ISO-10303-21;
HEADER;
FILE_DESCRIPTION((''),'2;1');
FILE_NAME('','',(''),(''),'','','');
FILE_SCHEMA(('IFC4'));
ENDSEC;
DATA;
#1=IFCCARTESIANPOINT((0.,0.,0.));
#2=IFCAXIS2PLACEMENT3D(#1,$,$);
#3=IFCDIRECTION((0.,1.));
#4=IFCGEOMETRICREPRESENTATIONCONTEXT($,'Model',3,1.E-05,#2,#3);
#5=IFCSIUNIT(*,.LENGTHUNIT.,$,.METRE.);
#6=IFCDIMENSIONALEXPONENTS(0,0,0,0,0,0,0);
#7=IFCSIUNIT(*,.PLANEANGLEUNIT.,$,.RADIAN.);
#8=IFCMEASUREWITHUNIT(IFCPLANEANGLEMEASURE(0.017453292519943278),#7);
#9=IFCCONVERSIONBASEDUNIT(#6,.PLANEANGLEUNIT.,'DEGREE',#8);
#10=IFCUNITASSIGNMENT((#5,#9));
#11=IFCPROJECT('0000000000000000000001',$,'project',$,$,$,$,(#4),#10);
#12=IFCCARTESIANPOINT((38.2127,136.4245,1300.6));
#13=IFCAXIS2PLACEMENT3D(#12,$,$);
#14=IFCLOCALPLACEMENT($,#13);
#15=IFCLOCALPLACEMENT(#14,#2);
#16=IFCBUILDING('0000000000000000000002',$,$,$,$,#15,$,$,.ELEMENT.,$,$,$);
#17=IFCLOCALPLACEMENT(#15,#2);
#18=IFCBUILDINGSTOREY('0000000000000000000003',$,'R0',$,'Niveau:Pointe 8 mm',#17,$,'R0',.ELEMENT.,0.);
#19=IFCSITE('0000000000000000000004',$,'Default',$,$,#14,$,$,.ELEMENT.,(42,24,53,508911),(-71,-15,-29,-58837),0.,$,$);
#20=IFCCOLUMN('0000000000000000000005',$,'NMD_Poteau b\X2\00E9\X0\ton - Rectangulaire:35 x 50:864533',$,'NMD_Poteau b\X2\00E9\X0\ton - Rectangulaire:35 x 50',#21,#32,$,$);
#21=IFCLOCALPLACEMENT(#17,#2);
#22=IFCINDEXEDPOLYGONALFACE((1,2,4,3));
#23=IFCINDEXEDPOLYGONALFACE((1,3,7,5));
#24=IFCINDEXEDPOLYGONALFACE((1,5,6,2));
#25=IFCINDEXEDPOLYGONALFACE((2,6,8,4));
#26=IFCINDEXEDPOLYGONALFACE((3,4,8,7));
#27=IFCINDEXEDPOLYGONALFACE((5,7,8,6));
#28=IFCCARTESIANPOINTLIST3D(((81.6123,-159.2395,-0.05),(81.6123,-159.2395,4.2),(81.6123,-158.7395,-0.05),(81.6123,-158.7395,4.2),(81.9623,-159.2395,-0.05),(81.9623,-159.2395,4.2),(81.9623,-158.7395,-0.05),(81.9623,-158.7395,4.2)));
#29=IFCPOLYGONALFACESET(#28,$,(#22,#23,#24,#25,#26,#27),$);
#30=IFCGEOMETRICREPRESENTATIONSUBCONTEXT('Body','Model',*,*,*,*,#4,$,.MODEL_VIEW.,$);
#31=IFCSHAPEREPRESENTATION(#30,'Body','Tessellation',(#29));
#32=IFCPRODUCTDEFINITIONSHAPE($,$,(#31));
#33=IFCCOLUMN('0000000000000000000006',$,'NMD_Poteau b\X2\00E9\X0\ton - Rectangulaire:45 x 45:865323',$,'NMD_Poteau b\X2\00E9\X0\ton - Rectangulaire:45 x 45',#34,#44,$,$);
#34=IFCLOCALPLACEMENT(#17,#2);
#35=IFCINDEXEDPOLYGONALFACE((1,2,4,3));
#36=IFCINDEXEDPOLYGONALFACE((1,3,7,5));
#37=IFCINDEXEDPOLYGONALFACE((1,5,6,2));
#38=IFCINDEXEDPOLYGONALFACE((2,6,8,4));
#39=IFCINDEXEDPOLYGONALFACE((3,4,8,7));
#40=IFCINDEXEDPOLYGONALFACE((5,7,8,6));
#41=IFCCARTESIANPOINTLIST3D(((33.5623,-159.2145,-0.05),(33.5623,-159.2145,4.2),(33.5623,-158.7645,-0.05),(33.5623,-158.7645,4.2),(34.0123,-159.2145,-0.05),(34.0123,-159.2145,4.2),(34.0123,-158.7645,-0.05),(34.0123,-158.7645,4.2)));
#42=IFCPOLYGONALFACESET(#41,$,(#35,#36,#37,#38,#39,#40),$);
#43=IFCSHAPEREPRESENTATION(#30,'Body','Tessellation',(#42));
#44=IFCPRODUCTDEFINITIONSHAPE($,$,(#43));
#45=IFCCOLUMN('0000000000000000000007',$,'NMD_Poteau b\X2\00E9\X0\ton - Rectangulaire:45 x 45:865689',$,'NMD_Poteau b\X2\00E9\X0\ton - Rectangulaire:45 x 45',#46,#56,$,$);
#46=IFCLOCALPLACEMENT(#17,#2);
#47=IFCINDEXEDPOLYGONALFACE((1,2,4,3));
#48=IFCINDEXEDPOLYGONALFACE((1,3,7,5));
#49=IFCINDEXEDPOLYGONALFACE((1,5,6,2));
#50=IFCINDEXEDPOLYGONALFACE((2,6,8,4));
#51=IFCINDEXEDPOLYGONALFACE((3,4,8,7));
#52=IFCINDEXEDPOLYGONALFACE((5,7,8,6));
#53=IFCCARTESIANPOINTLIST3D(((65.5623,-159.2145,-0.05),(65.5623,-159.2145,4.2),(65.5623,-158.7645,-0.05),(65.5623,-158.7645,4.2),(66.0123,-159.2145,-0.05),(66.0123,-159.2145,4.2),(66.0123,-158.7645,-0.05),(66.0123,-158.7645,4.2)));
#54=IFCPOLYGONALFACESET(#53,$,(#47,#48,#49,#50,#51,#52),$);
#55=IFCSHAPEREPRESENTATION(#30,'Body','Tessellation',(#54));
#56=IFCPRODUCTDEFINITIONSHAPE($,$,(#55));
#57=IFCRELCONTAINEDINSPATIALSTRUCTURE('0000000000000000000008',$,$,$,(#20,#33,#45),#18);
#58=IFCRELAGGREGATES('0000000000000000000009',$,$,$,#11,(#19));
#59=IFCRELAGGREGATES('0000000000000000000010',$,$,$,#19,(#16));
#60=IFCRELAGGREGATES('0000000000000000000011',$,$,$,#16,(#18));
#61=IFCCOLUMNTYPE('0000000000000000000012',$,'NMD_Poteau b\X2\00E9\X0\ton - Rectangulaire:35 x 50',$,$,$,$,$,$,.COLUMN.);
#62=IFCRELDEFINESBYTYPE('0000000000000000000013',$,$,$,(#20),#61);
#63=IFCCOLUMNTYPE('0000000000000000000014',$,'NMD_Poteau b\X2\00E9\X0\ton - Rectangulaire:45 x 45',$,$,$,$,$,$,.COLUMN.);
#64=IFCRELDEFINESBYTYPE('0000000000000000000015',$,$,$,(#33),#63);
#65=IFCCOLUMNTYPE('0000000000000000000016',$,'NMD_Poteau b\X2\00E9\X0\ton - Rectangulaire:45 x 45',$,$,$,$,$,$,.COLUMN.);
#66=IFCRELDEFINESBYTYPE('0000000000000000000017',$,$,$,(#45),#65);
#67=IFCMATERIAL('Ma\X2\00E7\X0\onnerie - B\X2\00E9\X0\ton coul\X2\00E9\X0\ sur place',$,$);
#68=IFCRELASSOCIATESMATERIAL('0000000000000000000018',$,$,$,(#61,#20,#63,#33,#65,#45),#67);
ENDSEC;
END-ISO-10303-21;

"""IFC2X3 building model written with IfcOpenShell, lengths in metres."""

from ifc_helpers import new_model, entity, si_unit, converted_unit, direction, frame, frame_2d, origin, origin_2d_with_axis, place, context, subcontext, project, spatial, rectangle, extrude, source, transform, mapped, material, type_object, type_shapes, element, save


model = new_model("IFC2X3")

# Units and contexts
model_context = context("Model", 3, precision=1e-05, world=origin(), true_north=direction((0.0, 1.0)))
body_context = subcontext(model_context, "Body", "Model", "MODEL_VIEW")
ifc_project = project(units=[si_unit("LENGTHUNIT", "METRE"), converted_unit("PLANEANGLEUNIT", "DEGREE", entity("IfcPlaneAngleMeasure", 0.017453292519943278), si_unit("PLANEANGLEUNIT", "RADIAN"), dimensions=[0, 0, 0, 0, 0, 0, 0])], contexts=[model_context])

# Site, building, storey
site_placement = place(None, frame((38.2127, 136.4245, 1300.6)))
site = spatial("IfcSite", under=ifc_project, at=site_placement, Name="Default", CompositionType="ELEMENT", RefLatitude=(42, 24, 53, 508911), RefLongitude=(-71, -15, -29, -58837), RefElevation=0.0)
building_placement = place(site_placement, origin())
building = spatial("IfcBuilding", under=site, at=building_placement, CompositionType="ELEMENT")
storey_placement = place(building_placement, origin())
storey = spatial("IfcBuildingStorey", under=building, at=storey_placement, Name="R0", ObjectType="Niveau:Pointe 8 mm", LongName="R0", CompositionType="ELEMENT", Elevation=0.0)

# Columns
ifc_material = material(Name="Maçonnerie - Béton coulé sur place")
column_type_1 = type_object("IfcColumnType", Name="NMD_Poteau béton - Rectangulaire:35 x 50", PredefinedType="COLUMN", material=ifc_material)
shared_shape_1 = source(origin(), body_context, "Body", "SweptSolid", [
    extrude(rectangle(XDim=0.35, YDim=0.5, at=frame_2d((0.0, 0.0), x_axis=(1.0, 0.0))), frame((81.7873, -158.9895, -0.05), z_axis=(0.0, 0.0, 1.0), x_axis=(-1.0, 0.0, 0.0)), (0.0, 0.0, 1.0), 4.25),
])
type_shapes(column_type_1, [shared_shape_1])
column_1_placement = place(storey_placement, origin())
element("IfcColumn", 1, at=column_1_placement, inside=storey, type_object=column_type_1, material=ifc_material, Name="NMD_Poteau béton - Rectangulaire:35 x 50:864533", ObjectType="NMD_Poteau béton - Rectangulaire:35 x 50", context=body_context, shape_type="MappedRepresentation", body=[
    mapped(shared_shape_1, transform((0.0, 0.0, 0.0), scale=1.0)),
])
column_type_2 = type_object("IfcColumnType", Name="NMD_Poteau béton - Rectangulaire:45 x 45", PredefinedType="COLUMN", material=ifc_material)
shared_shape_2 = source(origin(), body_context, "Body", "SweptSolid", [
    extrude(rectangle(XDim=0.45, YDim=0.45, at=origin_2d_with_axis()), frame((33.7873, -158.9895, -0.05), z_axis=(0.0, 0.0, 1.0), x_axis=(-1.0, 0.0, 0.0)), (0.0, 0.0, 1.0), 4.25),
])
type_shapes(column_type_2, [shared_shape_2])
column_2_placement = place(storey_placement, origin())
element("IfcColumn", 2, at=column_2_placement, inside=storey, type_object=column_type_2, material=ifc_material, Name="NMD_Poteau béton - Rectangulaire:45 x 45:865323", ObjectType="NMD_Poteau béton - Rectangulaire:45 x 45", context=body_context, shape_type="MappedRepresentation", body=[
    mapped(shared_shape_2, transform((0.0, 0.0, 0.0), scale=1.0)),
])
column_type_3 = type_object("IfcColumnType", Name="NMD_Poteau béton - Rectangulaire:45 x 45", PredefinedType="COLUMN", material=ifc_material)
shared_shape_3 = source(origin(), body_context, "Body", "SweptSolid", [
    extrude(rectangle(XDim=0.45, YDim=0.45, at=origin_2d_with_axis()), frame((65.7873, -158.9895, -0.05), z_axis=(0.0, 0.0, 1.0), x_axis=(-1.0, 0.0, 0.0)), (0.0, 0.0, 1.0), 4.25),
])
type_shapes(column_type_3, [shared_shape_3])
column_3_placement = place(storey_placement, origin())
element("IfcColumn", 3, at=column_3_placement, inside=storey, type_object=column_type_3, material=ifc_material, Name="NMD_Poteau béton - Rectangulaire:45 x 45:865689", ObjectType="NMD_Poteau béton - Rectangulaire:45 x 45", context=body_context, shape_type="MappedRepresentation", body=[
    mapped(shared_shape_3, transform((0.0, 0.0, 0.0), scale=1.0)),
])

save(model, "model.ifc")
